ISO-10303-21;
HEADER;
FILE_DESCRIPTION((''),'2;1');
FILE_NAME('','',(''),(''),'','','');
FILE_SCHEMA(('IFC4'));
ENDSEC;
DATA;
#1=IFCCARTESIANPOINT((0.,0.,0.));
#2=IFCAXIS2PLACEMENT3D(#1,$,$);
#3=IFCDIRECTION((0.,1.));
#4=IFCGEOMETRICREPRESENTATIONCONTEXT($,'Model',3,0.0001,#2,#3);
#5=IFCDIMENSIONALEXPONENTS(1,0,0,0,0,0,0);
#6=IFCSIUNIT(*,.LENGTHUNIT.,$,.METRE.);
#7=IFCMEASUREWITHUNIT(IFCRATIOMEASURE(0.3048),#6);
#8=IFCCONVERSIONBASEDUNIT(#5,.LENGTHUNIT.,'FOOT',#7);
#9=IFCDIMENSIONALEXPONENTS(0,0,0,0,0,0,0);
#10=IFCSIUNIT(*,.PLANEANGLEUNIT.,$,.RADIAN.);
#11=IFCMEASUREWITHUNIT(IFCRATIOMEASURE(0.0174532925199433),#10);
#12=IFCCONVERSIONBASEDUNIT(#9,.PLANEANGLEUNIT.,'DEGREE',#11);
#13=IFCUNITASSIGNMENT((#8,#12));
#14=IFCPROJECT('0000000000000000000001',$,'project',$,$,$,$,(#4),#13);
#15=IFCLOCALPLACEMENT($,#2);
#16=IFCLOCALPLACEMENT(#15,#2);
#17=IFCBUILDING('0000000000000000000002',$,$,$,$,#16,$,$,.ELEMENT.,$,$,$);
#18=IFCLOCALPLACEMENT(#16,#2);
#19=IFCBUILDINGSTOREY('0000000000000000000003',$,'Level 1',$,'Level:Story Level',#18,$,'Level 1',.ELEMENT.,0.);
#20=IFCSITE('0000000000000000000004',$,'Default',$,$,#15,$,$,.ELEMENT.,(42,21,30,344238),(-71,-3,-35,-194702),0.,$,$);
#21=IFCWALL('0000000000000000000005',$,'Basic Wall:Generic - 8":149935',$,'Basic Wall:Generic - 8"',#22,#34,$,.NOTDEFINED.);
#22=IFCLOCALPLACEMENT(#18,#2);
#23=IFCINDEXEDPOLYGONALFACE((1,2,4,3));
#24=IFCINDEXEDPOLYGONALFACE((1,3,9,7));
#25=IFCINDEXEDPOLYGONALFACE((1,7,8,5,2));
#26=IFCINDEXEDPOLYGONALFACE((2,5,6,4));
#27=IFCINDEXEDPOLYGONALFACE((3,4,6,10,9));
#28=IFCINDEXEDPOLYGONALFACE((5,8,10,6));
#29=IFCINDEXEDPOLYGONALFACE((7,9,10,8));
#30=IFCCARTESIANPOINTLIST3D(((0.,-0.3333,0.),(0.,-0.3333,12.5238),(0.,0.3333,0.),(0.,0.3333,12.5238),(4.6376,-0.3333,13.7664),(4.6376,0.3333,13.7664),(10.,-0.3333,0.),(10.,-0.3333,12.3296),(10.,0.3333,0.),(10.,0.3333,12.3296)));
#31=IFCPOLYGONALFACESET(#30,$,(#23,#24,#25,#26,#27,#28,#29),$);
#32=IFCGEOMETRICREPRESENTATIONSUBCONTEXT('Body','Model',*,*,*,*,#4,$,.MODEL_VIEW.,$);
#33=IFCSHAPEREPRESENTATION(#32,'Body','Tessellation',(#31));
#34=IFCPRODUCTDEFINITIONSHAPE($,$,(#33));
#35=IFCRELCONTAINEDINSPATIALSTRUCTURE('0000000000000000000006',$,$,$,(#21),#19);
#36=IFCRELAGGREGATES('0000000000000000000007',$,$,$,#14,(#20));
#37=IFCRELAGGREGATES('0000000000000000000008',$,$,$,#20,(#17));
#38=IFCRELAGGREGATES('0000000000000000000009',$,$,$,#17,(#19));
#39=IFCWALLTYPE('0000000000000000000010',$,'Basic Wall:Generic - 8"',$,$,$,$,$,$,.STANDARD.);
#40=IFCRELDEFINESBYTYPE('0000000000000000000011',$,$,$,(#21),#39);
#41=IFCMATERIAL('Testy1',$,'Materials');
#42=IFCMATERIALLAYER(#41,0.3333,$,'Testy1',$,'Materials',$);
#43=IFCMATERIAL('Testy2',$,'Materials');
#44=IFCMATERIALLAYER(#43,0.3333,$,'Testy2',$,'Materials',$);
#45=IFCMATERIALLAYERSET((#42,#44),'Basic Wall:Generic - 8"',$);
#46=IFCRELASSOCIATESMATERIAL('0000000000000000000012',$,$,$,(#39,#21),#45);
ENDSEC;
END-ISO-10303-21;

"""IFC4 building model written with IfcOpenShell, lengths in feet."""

from ifc_helpers import new_model, entity, si_unit, converted_unit, direction, frame, frame_2d, origin, place, context, subcontext, project, spatial, polyline, rectangle, extrude, clip, bounded_halfspace, material, layer, layer_set, layer_usage, type_object, element, save


model = new_model("IFC4")

# Units and contexts
model_context = context("Model", 3, precision=0.0001, world=origin(), true_north=direction((0.0, 1.0)))
body_context = subcontext(model_context, "Body", "Model", "MODEL_VIEW")
ifc_project = project(units=[converted_unit("LENGTHUNIT", "FOOT", entity("IfcRatioMeasure", 0.3048), si_unit("LENGTHUNIT", "METRE"), dimensions=[1, 0, 0, 0, 0, 0, 0]), converted_unit("PLANEANGLEUNIT", "DEGREE", entity("IfcRatioMeasure", 0.0174532925199433), si_unit("PLANEANGLEUNIT", "RADIAN"), dimensions=[0, 0, 0, 0, 0, 0, 0])], contexts=[model_context])

# Site, building, storey
site_placement = place(None, origin())
site = spatial("IfcSite", under=ifc_project, at=site_placement, Name="Default", CompositionType="ELEMENT", RefLatitude=(42, 21, 30, 344238), RefLongitude=(-71, -3, -35, -194702), RefElevation=0.0)
building_placement = place(site_placement, origin())
building = spatial("IfcBuilding", under=site, at=building_placement, CompositionType="ELEMENT")
storey_placement = place(building_placement, origin())
storey = spatial("IfcBuildingStorey", under=building, at=storey_placement, Name="Level 1", ObjectType="Level:Story Level", LongName="Level 1", CompositionType="ELEMENT", Elevation=0.0)

# Wall
ifc_material_1 = material(Name="Testy1", Category="Materials")
ifc_layer_1 = layer(ifc_material_1, 0.3333, Name="Testy1", Category="Materials")
ifc_material_2 = material(Name="Testy2", Category="Materials")
ifc_layer_2 = layer(ifc_material_2, 0.3333, Name="Testy2", Category="Materials")
ifc_layer_set = layer_set([ifc_layer_1, ifc_layer_2], Name="Basic Wall:Generic - 8\"")
ifc_layer_usage = layer_usage(ifc_layer_set, "AXIS2", "NEGATIVE", 0.3333)
wall_type = type_object("IfcWallType", Name="Basic Wall:Generic - 8\"", PredefinedType="STANDARD", material=ifc_layer_set)
wall_placement = place(storey_placement, origin())
element("IfcWall", 1, at=wall_placement, inside=storey, type_object=wall_type, material=ifc_layer_usage, Name="Basic Wall:Generic - 8\":149935", ObjectType="Basic Wall:Generic - 8\"", PredefinedType="NOTDEFINED", context=body_context, shape_type="Clipping", body=[
    clip(clip(extrude(rectangle(XDim=10.0, YDim=0.6667, at=frame_2d((5.0, 0.0), x_axis=(-1.0, 0.0))), origin(), (0.0, 0.0, 1.0), 13.7664), bounded_halfspace(frame((4.6376, -0.3333, 13.7664), z_axis=(0.258819, 0.0, 0.965926), x_axis=(0.0, 1.0, 0.0)), False, frame((4.6376, -0.3333, 13.7664)), polyline([(0.0, 0.0), (5.3624, 0.0), (5.3624, 0.6667), (0.0, 0.6667), (0.0, 0.0)]))), bounded_halfspace(frame((0.0, -0.3333, 12.5238), z_axis=(-0.258819, 0.0, 0.965926), x_axis=(0.0, -1.0, 0.0)), False, frame((0.0, -0.3333, 12.5238)), polyline([(0.0, 0.0), (4.6376, 0.0), (4.6376, 0.6667), (0.0, 0.6667), (0.0, 0.0)]))),
])

save(model, "model.ifc")
